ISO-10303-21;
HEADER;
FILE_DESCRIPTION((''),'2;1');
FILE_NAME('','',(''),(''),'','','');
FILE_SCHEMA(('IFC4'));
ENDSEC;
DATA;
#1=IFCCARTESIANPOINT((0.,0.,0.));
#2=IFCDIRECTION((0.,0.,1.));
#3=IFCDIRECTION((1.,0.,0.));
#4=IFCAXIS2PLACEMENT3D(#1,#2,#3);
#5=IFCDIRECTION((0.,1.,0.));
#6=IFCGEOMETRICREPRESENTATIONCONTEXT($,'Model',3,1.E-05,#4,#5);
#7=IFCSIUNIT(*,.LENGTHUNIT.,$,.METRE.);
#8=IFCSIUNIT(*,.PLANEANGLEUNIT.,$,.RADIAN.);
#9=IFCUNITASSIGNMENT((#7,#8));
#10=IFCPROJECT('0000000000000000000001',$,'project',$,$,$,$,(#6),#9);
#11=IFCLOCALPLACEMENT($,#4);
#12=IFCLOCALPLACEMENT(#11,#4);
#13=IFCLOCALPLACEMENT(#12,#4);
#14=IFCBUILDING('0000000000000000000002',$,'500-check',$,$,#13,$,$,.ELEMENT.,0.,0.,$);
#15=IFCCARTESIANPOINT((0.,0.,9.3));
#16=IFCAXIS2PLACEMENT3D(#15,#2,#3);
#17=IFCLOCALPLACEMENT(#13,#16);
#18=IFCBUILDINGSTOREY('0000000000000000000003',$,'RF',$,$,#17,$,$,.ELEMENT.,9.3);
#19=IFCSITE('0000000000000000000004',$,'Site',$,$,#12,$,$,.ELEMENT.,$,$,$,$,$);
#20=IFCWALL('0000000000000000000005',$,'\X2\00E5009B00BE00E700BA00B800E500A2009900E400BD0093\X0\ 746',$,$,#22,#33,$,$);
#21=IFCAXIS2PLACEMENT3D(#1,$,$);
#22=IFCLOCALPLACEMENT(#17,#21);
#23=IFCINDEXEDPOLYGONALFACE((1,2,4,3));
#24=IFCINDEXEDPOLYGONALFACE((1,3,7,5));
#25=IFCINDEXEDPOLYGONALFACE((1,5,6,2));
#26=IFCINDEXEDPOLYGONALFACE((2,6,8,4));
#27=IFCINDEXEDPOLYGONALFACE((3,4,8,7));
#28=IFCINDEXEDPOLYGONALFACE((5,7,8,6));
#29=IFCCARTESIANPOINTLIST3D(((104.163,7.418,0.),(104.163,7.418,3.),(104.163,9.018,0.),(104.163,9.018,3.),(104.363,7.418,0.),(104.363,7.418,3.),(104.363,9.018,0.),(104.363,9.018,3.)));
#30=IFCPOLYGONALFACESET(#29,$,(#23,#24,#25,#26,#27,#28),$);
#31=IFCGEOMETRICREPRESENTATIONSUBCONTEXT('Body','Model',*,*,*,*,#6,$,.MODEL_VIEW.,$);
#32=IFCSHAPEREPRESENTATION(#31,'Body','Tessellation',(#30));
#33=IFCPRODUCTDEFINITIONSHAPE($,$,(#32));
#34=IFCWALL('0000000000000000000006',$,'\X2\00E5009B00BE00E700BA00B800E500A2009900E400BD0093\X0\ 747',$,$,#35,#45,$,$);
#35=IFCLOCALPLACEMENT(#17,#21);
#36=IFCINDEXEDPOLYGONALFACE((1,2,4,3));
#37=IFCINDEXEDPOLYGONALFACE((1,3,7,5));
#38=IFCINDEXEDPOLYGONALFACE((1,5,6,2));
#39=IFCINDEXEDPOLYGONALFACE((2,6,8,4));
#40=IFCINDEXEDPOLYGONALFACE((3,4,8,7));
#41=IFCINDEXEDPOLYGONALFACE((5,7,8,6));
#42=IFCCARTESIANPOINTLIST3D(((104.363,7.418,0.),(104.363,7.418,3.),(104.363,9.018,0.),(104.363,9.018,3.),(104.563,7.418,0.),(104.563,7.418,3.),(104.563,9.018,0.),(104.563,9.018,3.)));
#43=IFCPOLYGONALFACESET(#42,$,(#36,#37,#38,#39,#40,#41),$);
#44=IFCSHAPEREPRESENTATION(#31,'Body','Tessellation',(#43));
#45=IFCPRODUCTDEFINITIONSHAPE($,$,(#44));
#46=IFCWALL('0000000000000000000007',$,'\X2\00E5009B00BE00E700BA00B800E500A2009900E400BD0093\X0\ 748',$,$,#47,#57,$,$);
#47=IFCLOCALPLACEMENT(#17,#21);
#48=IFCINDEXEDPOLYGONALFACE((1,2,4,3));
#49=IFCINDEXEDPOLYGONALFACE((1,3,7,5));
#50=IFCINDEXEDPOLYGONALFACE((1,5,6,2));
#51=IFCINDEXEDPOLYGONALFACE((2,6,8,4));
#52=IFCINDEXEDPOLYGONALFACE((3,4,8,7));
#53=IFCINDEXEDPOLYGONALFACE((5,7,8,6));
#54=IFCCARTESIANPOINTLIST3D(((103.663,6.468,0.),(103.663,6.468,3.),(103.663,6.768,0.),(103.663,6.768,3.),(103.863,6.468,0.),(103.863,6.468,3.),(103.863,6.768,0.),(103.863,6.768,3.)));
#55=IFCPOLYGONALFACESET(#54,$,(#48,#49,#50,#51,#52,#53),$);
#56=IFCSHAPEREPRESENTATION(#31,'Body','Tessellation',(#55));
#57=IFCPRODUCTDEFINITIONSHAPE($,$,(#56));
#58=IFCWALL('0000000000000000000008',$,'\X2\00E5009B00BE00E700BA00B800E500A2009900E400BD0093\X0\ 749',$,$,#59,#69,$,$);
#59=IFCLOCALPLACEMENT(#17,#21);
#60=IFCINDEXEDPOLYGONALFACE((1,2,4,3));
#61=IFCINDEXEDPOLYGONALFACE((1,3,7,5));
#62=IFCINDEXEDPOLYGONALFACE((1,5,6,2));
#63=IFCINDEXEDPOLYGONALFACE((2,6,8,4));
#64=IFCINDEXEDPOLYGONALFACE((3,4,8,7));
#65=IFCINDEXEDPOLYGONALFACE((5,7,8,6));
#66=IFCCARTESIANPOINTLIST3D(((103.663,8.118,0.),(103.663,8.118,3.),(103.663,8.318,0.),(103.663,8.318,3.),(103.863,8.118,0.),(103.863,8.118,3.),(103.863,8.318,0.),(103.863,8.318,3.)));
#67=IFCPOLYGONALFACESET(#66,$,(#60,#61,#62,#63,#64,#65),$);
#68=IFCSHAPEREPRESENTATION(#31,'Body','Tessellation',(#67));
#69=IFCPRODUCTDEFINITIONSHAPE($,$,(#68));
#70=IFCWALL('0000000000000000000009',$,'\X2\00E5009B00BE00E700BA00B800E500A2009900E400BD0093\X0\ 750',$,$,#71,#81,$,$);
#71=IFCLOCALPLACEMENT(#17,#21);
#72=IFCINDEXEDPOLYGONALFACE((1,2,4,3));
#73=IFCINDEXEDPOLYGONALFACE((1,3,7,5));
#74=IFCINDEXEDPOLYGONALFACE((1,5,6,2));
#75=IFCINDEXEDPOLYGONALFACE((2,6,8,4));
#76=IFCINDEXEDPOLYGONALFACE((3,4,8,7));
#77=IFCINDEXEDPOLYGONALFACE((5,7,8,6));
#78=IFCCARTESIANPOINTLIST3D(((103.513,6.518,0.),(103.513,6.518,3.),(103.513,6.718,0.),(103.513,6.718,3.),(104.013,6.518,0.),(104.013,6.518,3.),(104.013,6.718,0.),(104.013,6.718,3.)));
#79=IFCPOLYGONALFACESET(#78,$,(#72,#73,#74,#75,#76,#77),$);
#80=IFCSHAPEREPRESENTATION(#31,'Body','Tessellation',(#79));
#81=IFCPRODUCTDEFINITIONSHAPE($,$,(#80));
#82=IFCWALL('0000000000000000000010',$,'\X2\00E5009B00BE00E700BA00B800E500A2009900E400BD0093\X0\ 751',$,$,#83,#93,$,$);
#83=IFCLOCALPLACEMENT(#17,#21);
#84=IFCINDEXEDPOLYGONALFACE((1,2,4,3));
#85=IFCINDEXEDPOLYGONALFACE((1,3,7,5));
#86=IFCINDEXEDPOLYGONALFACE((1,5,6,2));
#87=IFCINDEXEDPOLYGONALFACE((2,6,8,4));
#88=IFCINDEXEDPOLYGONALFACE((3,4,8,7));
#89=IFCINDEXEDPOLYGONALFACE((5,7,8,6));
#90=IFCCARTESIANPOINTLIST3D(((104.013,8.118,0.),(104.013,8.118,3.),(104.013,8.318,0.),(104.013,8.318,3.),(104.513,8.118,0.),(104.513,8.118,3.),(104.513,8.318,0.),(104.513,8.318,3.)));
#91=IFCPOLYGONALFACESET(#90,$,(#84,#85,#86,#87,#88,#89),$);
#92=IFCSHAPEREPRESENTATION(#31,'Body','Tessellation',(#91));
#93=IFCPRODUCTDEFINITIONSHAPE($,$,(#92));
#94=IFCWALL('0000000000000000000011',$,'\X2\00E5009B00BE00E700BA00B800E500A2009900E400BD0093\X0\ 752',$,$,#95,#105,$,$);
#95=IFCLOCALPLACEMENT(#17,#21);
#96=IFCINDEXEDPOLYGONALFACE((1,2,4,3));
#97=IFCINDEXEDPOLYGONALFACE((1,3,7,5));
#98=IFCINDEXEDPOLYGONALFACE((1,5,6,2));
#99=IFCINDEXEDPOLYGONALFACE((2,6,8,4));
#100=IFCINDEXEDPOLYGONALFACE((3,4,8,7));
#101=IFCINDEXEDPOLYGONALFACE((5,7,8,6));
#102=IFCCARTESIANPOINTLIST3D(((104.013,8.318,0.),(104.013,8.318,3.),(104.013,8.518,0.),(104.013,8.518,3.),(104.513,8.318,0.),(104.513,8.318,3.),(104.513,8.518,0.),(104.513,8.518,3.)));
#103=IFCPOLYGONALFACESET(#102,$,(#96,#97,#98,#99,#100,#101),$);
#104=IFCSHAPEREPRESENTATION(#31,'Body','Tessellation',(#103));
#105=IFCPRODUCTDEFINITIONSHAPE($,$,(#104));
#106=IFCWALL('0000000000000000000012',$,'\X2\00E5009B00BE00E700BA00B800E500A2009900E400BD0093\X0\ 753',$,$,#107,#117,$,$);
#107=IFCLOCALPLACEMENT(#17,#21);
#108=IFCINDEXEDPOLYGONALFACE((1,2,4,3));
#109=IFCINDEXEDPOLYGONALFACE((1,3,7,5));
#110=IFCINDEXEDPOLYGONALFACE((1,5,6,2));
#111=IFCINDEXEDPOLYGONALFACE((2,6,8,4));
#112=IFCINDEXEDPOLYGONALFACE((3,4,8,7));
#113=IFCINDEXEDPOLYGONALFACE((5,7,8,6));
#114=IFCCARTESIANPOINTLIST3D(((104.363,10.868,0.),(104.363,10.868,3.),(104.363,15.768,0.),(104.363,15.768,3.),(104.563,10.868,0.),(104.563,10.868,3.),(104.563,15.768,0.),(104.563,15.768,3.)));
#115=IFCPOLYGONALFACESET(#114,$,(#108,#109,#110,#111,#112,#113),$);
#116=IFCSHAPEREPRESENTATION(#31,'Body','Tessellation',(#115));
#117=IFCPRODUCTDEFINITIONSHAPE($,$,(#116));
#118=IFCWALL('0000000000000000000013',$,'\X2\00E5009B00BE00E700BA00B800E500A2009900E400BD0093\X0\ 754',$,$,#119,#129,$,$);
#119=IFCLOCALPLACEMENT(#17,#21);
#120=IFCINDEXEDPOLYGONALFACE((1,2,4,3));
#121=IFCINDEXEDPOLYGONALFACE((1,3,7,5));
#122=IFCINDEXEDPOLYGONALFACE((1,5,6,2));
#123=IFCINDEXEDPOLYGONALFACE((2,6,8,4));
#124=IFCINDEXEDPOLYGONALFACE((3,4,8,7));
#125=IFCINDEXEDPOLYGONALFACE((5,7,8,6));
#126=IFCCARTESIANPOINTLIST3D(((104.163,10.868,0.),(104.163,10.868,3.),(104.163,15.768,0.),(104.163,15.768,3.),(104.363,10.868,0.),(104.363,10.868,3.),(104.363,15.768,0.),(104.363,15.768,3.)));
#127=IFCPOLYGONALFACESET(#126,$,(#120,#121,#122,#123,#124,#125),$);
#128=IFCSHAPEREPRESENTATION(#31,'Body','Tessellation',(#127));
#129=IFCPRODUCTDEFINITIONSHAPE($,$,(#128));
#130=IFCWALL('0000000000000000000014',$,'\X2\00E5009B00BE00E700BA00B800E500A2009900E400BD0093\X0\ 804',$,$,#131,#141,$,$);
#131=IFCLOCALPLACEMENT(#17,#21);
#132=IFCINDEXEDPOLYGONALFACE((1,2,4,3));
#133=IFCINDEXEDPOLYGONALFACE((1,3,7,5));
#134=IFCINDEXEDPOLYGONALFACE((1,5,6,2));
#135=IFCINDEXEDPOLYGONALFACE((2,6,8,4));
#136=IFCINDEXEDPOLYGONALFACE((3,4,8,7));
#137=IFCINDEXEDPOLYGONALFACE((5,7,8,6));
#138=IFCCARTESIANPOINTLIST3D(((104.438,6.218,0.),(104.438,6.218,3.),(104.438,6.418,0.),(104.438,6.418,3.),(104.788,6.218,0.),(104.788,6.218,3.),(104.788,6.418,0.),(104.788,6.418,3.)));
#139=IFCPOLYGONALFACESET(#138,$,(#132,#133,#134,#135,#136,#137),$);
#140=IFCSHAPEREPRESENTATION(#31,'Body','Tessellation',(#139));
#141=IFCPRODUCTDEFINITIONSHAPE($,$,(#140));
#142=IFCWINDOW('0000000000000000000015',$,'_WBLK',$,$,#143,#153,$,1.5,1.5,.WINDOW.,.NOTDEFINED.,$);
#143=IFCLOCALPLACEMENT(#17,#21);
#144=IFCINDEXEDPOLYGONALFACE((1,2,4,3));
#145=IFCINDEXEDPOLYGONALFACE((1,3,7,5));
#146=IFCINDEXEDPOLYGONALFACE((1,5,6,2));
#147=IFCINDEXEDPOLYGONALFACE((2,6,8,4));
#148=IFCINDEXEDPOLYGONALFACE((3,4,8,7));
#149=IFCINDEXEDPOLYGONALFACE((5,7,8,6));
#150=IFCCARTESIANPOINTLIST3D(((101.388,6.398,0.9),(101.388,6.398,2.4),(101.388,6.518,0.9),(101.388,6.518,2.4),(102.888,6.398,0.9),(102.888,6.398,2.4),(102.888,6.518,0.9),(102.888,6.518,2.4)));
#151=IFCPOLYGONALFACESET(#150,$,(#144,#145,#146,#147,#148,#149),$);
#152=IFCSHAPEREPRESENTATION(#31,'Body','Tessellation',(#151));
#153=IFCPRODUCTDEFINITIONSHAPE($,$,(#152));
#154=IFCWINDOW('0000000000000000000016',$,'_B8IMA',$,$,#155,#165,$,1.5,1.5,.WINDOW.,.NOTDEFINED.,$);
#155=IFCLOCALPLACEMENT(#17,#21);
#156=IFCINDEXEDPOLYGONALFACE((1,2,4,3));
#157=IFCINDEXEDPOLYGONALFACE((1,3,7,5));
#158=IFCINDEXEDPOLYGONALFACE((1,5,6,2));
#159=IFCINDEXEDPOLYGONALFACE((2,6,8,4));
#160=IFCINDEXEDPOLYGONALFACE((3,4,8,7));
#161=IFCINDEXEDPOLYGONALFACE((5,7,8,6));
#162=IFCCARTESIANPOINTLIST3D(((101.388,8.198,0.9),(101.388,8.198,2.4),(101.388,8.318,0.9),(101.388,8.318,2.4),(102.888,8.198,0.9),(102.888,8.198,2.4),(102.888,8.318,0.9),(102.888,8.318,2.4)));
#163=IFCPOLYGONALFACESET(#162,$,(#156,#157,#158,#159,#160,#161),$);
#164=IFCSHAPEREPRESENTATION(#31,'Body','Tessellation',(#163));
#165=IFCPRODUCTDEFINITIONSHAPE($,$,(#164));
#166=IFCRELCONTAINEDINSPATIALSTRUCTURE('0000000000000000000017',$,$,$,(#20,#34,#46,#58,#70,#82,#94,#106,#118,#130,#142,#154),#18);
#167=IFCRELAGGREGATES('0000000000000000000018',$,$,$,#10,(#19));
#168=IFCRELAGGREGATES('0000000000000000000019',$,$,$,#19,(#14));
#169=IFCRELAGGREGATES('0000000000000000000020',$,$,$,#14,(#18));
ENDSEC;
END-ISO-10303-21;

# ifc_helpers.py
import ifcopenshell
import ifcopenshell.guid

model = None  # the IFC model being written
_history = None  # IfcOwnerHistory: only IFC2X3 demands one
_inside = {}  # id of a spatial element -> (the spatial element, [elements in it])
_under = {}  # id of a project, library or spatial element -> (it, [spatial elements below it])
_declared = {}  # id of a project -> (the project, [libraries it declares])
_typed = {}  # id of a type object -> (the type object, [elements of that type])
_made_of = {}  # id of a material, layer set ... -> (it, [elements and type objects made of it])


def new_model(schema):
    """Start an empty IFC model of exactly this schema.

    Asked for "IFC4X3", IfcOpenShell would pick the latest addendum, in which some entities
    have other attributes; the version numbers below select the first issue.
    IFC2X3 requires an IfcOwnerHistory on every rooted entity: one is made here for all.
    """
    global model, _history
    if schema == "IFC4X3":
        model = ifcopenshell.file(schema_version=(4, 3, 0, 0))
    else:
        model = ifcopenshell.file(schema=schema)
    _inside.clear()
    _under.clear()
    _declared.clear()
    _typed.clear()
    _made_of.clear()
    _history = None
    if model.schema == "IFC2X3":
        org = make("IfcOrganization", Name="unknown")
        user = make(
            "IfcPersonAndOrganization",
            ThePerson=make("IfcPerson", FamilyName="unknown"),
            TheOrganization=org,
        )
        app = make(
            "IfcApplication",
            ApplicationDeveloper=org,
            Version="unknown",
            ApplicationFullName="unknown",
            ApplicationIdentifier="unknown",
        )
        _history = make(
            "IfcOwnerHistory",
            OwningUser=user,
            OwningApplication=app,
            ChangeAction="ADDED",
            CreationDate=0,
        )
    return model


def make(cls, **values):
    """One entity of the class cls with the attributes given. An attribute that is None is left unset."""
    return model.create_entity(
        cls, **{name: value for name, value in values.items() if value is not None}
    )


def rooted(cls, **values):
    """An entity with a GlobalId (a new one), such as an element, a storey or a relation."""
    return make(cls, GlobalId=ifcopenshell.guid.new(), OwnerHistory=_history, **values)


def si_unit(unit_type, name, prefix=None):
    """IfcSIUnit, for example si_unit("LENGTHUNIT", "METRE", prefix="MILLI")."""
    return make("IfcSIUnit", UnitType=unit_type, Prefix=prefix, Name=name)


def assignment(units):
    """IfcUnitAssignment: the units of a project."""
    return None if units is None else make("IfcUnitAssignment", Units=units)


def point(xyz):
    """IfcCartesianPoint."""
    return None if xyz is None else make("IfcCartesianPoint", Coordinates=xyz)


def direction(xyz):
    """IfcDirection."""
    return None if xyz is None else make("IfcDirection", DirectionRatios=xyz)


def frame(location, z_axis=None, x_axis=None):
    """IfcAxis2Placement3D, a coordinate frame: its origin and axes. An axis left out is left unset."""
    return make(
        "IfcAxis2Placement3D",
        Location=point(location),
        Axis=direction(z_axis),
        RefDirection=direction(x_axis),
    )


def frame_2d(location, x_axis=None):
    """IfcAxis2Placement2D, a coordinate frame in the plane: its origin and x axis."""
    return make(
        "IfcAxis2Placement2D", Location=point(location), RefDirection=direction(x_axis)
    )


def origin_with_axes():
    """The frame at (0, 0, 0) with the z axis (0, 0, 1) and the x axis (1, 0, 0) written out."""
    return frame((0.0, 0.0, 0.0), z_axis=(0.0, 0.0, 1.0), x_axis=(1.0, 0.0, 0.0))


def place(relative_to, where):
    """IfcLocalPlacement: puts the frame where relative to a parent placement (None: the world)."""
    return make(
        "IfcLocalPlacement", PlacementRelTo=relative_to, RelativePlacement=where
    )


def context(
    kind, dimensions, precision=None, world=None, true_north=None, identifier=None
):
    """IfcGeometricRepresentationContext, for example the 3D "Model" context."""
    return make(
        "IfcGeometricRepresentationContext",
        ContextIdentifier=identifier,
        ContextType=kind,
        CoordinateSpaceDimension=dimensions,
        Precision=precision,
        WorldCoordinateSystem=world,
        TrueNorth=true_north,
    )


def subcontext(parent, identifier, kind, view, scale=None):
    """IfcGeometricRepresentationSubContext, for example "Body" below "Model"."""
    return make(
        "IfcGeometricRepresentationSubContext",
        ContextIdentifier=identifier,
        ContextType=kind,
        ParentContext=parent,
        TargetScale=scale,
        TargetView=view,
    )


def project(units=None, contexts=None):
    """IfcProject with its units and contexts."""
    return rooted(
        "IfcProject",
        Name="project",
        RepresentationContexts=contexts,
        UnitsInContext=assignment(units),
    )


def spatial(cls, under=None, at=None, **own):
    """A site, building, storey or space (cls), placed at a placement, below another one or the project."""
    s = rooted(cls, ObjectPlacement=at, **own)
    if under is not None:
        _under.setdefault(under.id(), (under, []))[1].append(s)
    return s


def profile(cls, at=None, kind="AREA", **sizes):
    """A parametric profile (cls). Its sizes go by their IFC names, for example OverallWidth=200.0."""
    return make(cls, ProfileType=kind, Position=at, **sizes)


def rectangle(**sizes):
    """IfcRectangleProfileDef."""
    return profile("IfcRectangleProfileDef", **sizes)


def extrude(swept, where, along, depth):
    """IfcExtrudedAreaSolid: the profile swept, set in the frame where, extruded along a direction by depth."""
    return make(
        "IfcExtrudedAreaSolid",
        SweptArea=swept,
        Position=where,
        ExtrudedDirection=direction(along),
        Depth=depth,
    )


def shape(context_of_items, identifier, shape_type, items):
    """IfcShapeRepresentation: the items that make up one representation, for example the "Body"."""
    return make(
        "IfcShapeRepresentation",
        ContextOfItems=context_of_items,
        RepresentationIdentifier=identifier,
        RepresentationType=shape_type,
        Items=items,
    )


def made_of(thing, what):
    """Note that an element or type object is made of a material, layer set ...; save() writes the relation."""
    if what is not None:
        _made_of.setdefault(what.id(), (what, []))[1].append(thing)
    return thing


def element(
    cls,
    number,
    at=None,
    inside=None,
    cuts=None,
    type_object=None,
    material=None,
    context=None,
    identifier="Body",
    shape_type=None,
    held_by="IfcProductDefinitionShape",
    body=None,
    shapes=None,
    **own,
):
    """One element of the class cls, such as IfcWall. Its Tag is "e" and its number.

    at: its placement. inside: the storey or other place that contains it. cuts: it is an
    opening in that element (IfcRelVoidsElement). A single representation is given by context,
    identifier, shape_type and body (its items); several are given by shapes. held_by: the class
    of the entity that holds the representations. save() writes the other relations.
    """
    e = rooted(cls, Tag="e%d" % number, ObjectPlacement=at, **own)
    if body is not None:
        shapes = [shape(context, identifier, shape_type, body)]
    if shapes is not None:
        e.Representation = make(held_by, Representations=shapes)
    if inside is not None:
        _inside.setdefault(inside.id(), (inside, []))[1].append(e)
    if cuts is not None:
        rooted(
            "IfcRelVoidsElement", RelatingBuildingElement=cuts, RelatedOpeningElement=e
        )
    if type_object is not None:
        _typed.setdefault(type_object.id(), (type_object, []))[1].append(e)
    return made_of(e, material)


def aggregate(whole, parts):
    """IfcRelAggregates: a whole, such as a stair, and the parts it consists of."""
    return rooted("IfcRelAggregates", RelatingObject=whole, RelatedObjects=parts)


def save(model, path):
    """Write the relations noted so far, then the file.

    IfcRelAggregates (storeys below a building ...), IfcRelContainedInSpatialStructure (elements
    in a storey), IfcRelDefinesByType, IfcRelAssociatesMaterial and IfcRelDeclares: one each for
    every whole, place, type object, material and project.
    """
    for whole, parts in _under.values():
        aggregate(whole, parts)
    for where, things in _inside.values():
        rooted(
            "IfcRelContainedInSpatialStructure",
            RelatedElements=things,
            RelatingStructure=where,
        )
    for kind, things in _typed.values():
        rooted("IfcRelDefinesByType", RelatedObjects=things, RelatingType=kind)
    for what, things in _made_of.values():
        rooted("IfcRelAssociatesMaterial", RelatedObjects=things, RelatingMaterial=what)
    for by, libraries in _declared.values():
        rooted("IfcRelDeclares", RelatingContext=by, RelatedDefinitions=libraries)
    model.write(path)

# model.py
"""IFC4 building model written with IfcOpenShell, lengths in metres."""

from ifc_helpers import new_model, si_unit, direction, frame, frame_2d, origin_with_axes, place, context, subcontext, project, spatial, rectangle, extrude, element, save


model = new_model("IFC4")

# Units and contexts
model_context = context("Model", 3, precision=1e-05, world=origin_with_axes(), true_north=direction((0.0, 1.0, 0.0)))
body_context = subcontext(model_context, "Body", "Model", "MODEL_VIEW")
ifc_project = project(units=[si_unit("LENGTHUNIT", "METRE"), si_unit("PLANEANGLEUNIT", "RADIAN")], contexts=[model_context])

# Site, building, storey
placement = place(None, origin_with_axes())
site_placement = place(placement, origin_with_axes())
site = spatial("IfcSite", under=ifc_project, at=site_placement, Name="Site", CompositionType="ELEMENT")
building_placement = place(site_placement, origin_with_axes())
building = spatial("IfcBuilding", under=site, at=building_placement, Name="500-check", CompositionType="ELEMENT", ElevationOfRefHeight=0.0, ElevationOfTerrain=0.0)
storey_placement = place(building_placement, frame((0.0, 0.0, 9.3), z_axis=(0.0, 0.0, 1.0), x_axis=(1.0, 0.0, 0.0)))
storey = spatial("IfcBuildingStorey", under=building, at=storey_placement, Name="RF", CompositionType="ELEMENT", Elevation=9.3)

# Walls
for number, where, z_axis, x_axis, name in (
    (1, (104.263, 8.218, 0.0), (0.0, 0.0, 1.0), (0.0, -1.0, 0.0), "å\u009b¾çº¸å¢\u0099ä½\u0093 746"),
    (2, (104.463, 8.218, 0.0), (0.0, 0.0, 1.0), (0.0, -1.0, 0.0), "å\u009b¾çº¸å¢\u0099ä½\u0093 747"),
):
    element("IfcWall", number, at=place(storey_placement, frame(where, z_axis=z_axis, x_axis=x_axis)), inside=storey, Name=name, context=body_context, shape_type="SweptSolid", body=[
        extrude(rectangle(XDim=1.6, YDim=0.2, at=frame_2d((0.0, 0.0), x_axis=(1.0, 0.0, 0.0))), frame((0.0, 0.0, 0.0), z_axis=(0.0, 0.0, 1.0)), (0.0, 0.0, 1.0), 3.0),
    ])
wall_1_placement = place(storey_placement, frame((103.763, 6.618, 0.0), z_axis=(0.0, 0.0, 1.0), x_axis=(0.0, -1.0, 0.0)))
element("IfcWall", 3, at=wall_1_placement, inside=storey, Name="å\u009b¾çº¸å¢\u0099ä½\u0093 748", context=body_context, shape_type="SweptSolid", body=[
    extrude(rectangle(XDim=0.3, YDim=0.2, at=frame_2d((0.0, 0.0), x_axis=(1.0, 0.0, 0.0))), frame((0.0, 0.0, 0.0), z_axis=(0.0, 0.0, 1.0)), (0.0, 0.0, 1.0), 3.0),
])
wall_2_placement = place(storey_placement, frame((103.763, 8.218, 0.0), z_axis=(0.0, 0.0, 1.0), x_axis=(0.0, 1.0, 0.0)))
element("IfcWall", 4, at=wall_2_placement, inside=storey, Name="å\u009b¾çº¸å¢\u0099ä½\u0093 749", context=body_context, shape_type="SweptSolid", body=[
    extrude(rectangle(XDim=0.2, YDim=0.2, at=frame_2d((0.0, 0.0), x_axis=(1.0, 0.0, 0.0))), frame((0.0, 0.0, 0.0), z_axis=(0.0, 0.0, 1.0)), (0.0, 0.0, 1.0), 3.0),
])
for number, where, z_axis, x_axis, name in (
    (5, (103.763, 6.618, 0.0), (0.0, 0.0, 1.0), (1.0, 0.0, 0.0), "å\u009b¾çº¸å¢\u0099ä½\u0093 750"),
    (6, (104.263, 8.218, 0.0), (0.0, 0.0, 1.0), (-1.0, 0.0, 0.0), "å\u009b¾çº¸å¢\u0099ä½\u0093 751"),
    (7, (104.263, 8.418, 0.0), (0.0, 0.0, 1.0), (-1.0, 0.0, 0.0), "å\u009b¾çº¸å¢\u0099ä½\u0093 752"),
):
    element("IfcWall", number, at=place(storey_placement, frame(where, z_axis=z_axis, x_axis=x_axis)), inside=storey, Name=name, context=body_context, shape_type="SweptSolid", body=[
        extrude(rectangle(XDim=0.5, YDim=0.2, at=frame_2d((0.0, 0.0), x_axis=(1.0, 0.0, 0.0))), frame((0.0, 0.0, 0.0), z_axis=(0.0, 0.0, 1.0)), (0.0, 0.0, 1.0), 3.0),
    ])
for number, where, z_axis, x_axis, name in (
    (8, (104.463, 13.318, 0.0), (0.0, 0.0, 1.0), (0.0, -1.0, 0.0), "å\u009b¾çº¸å¢\u0099ä½\u0093 753"),
    (9, (104.263, 13.318, 0.0), (0.0, 0.0, 1.0), (0.0, -1.0, 0.0), "å\u009b¾çº¸å¢\u0099ä½\u0093 754"),
):
    element("IfcWall", number, at=place(storey_placement, frame(where, z_axis=z_axis, x_axis=x_axis)), inside=storey, Name=name, context=body_context, shape_type="SweptSolid", body=[
        extrude(rectangle(XDim=4.9, YDim=0.2, at=frame_2d((0.0, 0.0), x_axis=(1.0, 0.0, 0.0))), frame((0.0, 0.0, 0.0), z_axis=(0.0, 0.0, 1.0)), (0.0, 0.0, 1.0), 3.0),
    ])
wall_3_placement = place(storey_placement, frame((104.613, 6.318, 0.0), z_axis=(0.0, 0.0, 1.0), x_axis=(1.0, 0.0, 0.0)))
element("IfcWall", 10, at=wall_3_placement, inside=storey, Name="å\u009b¾çº¸å¢\u0099ä½\u0093 804", context=body_context, shape_type="SweptSolid", body=[
    extrude(rectangle(XDim=0.35, YDim=0.2, at=frame_2d((0.0, 0.0), x_axis=(1.0, 0.0, 0.0))), frame((0.0, 0.0, 0.0), z_axis=(0.0, 0.0, 1.0)), (0.0, 0.0, 1.0), 3.0),
])

# Windows
for number, where, z_axis, x_axis, name in (
    (11, (102.138, 6.458, 0.9), (0.0, 0.0, 1.0), (1.0, 0.0, 0.0), "_WBLK"),
    (12, (102.138, 8.258, 0.9), (0.0, 0.0, 1.0), (1.0, 0.0, 0.0), "_B8IMA"),
):
    element("IfcWindow", number, at=place(storey_placement, frame(where, z_axis=z_axis, x_axis=x_axis)), inside=storey, Name=name, OverallHeight=1.5, OverallWidth=1.5, PartitioningType="NOTDEFINED", PredefinedType="WINDOW", context=body_context, shape_type="SweptSolid", body=[
        extrude(rectangle(XDim=1.5, YDim=0.12, at=frame_2d((0.0, 0.0), x_axis=(1.0, 0.0, 0.0))), frame((0.0, 0.0, 0.0), z_axis=(0.0, 0.0, 1.0)), (0.0, 0.0, 1.0), 1.5),
    ])

save(model, "model.ifc")
